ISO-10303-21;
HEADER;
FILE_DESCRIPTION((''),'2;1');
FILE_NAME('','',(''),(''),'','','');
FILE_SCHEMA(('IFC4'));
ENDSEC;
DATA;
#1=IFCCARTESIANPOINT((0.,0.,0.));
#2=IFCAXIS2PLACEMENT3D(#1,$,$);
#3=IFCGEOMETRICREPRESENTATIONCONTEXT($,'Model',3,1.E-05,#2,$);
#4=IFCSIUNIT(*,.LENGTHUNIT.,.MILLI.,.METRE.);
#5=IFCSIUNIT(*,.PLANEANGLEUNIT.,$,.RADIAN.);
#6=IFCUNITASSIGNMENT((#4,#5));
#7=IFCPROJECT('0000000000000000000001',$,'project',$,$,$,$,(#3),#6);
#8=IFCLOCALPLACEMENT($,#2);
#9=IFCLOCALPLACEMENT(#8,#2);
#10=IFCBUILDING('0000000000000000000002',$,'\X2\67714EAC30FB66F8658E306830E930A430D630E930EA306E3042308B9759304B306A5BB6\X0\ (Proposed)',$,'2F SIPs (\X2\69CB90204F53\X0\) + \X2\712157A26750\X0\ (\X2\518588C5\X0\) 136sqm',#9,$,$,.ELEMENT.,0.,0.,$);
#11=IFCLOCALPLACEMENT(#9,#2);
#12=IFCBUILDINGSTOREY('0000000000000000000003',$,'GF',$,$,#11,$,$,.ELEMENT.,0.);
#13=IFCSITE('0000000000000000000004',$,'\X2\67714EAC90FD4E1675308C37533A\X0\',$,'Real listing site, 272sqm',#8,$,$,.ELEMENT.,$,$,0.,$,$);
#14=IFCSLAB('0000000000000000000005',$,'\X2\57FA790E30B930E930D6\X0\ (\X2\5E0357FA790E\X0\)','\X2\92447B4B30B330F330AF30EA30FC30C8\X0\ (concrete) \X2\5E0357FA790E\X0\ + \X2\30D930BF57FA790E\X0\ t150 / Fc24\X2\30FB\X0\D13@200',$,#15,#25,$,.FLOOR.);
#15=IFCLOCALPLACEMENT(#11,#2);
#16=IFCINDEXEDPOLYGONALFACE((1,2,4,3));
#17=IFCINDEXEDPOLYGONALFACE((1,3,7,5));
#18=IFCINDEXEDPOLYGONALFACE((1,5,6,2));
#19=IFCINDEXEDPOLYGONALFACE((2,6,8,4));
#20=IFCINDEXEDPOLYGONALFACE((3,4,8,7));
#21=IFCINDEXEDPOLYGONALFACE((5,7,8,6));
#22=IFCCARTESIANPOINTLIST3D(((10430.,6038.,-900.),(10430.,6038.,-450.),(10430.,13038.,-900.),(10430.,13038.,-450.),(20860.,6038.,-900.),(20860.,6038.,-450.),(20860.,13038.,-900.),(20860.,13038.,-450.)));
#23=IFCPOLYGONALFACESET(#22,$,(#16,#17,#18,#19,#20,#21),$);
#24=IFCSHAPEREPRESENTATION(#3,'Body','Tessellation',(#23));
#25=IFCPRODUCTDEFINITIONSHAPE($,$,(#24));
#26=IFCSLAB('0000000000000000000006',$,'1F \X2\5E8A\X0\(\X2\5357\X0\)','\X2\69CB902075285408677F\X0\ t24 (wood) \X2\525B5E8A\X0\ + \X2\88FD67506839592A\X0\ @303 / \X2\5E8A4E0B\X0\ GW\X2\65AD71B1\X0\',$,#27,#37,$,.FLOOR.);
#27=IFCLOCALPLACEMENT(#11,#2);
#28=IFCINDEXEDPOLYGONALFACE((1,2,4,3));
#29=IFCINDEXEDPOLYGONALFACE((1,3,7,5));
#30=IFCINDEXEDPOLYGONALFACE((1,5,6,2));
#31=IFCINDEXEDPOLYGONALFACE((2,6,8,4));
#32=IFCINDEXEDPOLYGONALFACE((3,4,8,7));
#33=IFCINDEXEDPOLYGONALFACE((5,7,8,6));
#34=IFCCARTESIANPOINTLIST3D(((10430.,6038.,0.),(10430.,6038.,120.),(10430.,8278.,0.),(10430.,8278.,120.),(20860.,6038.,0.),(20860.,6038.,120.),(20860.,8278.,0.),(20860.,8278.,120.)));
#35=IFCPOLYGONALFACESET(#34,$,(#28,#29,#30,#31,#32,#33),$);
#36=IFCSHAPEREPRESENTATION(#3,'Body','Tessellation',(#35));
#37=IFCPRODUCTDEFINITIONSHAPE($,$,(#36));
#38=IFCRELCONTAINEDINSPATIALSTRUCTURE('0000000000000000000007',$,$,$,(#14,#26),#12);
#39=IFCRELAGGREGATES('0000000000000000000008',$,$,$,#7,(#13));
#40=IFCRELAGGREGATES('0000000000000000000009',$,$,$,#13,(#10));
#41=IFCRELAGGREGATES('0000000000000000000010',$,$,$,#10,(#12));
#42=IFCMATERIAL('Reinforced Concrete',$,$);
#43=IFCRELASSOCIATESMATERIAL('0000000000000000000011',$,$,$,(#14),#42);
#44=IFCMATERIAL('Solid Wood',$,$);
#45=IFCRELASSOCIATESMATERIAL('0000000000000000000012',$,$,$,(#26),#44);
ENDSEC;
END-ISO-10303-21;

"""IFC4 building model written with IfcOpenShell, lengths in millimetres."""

from ifc_helpers import new_model, si_unit, frame, frame_2d, origin, place, context, project, spatial, rectangle, extrude, material, element, save


model = new_model("IFC4")

# Units and contexts
model_context = context("Model", 3, precision=1e-05, world=origin())
ifc_project = project(units=[si_unit("LENGTHUNIT", "METRE", prefix="MILLI"), si_unit("PLANEANGLEUNIT", "RADIAN")], contexts=[model_context])

# Site, building, storey
site_placement = place(None, origin())
site = spatial("IfcSite", under=ifc_project, at=site_placement, Name="東京都世田谷区", ObjectType="Real listing site, 272sqm", CompositionType="ELEMENT", RefElevation=0.0)
building_placement = place(site_placement, origin())
building = spatial("IfcBuilding", under=site, at=building_placement, Name="東京・書斎とライブラリのある静かな家 (Proposed)", ObjectType="2F SIPs (構造体) + 無垢材 (内装) 136sqm", CompositionType="ELEMENT", ElevationOfRefHeight=0.0, ElevationOfTerrain=0.0)
storey_placement = place(building_placement, origin())
storey = spatial("IfcBuildingStorey", under=building, at=storey_placement, Name="GF", CompositionType="ELEMENT", Elevation=0.0)

# Slabs
ifc_material_1 = material(Name="Reinforced Concrete")
slab_1_placement = place(storey_placement, frame((5215.0, 3019.0, -450.0)))
element("IfcSlab", 1, at=slab_1_placement, inside=storey, material=ifc_material_1, Name="基礎スラブ (布基礎)", Description="鉄筋コンクリート (concrete) 布基礎 + ベタ基礎 t150 / Fc24・D13@200", PredefinedType="FLOOR", context=model_context, shape_type="SweptSolid", body=[
    extrude(rectangle(XDim=10430.0, YDim=7000.0, at=frame_2d((5215.0, 3500.0))), frame((5215.0, 3019.0, -450.0)), (0.0, 0.0, 1.0), 450.0),
])
ifc_material_2 = material(Name="Solid Wood")
slab_2_placement = place(storey_placement, frame((5215.0, 3019.0, 0.0)))
element("IfcSlab", 2, at=slab_2_placement, inside=storey, material=ifc_material_2, Name="1F 床(南)", Description="構造用合板 t24 (wood) 剛床 + 製材根太 @303 / 床下 GW断熱", PredefinedType="FLOOR", context=model_context, shape_type="SweptSolid", body=[
    extrude(rectangle(XDim=10430.0, YDim=2240.0, at=frame_2d((5215.0, 1120.0))), frame((5215.0, 3019.0, 0.0)), (0.0, 0.0, 1.0), 120.0),
])

save(model, "model.ifc")
